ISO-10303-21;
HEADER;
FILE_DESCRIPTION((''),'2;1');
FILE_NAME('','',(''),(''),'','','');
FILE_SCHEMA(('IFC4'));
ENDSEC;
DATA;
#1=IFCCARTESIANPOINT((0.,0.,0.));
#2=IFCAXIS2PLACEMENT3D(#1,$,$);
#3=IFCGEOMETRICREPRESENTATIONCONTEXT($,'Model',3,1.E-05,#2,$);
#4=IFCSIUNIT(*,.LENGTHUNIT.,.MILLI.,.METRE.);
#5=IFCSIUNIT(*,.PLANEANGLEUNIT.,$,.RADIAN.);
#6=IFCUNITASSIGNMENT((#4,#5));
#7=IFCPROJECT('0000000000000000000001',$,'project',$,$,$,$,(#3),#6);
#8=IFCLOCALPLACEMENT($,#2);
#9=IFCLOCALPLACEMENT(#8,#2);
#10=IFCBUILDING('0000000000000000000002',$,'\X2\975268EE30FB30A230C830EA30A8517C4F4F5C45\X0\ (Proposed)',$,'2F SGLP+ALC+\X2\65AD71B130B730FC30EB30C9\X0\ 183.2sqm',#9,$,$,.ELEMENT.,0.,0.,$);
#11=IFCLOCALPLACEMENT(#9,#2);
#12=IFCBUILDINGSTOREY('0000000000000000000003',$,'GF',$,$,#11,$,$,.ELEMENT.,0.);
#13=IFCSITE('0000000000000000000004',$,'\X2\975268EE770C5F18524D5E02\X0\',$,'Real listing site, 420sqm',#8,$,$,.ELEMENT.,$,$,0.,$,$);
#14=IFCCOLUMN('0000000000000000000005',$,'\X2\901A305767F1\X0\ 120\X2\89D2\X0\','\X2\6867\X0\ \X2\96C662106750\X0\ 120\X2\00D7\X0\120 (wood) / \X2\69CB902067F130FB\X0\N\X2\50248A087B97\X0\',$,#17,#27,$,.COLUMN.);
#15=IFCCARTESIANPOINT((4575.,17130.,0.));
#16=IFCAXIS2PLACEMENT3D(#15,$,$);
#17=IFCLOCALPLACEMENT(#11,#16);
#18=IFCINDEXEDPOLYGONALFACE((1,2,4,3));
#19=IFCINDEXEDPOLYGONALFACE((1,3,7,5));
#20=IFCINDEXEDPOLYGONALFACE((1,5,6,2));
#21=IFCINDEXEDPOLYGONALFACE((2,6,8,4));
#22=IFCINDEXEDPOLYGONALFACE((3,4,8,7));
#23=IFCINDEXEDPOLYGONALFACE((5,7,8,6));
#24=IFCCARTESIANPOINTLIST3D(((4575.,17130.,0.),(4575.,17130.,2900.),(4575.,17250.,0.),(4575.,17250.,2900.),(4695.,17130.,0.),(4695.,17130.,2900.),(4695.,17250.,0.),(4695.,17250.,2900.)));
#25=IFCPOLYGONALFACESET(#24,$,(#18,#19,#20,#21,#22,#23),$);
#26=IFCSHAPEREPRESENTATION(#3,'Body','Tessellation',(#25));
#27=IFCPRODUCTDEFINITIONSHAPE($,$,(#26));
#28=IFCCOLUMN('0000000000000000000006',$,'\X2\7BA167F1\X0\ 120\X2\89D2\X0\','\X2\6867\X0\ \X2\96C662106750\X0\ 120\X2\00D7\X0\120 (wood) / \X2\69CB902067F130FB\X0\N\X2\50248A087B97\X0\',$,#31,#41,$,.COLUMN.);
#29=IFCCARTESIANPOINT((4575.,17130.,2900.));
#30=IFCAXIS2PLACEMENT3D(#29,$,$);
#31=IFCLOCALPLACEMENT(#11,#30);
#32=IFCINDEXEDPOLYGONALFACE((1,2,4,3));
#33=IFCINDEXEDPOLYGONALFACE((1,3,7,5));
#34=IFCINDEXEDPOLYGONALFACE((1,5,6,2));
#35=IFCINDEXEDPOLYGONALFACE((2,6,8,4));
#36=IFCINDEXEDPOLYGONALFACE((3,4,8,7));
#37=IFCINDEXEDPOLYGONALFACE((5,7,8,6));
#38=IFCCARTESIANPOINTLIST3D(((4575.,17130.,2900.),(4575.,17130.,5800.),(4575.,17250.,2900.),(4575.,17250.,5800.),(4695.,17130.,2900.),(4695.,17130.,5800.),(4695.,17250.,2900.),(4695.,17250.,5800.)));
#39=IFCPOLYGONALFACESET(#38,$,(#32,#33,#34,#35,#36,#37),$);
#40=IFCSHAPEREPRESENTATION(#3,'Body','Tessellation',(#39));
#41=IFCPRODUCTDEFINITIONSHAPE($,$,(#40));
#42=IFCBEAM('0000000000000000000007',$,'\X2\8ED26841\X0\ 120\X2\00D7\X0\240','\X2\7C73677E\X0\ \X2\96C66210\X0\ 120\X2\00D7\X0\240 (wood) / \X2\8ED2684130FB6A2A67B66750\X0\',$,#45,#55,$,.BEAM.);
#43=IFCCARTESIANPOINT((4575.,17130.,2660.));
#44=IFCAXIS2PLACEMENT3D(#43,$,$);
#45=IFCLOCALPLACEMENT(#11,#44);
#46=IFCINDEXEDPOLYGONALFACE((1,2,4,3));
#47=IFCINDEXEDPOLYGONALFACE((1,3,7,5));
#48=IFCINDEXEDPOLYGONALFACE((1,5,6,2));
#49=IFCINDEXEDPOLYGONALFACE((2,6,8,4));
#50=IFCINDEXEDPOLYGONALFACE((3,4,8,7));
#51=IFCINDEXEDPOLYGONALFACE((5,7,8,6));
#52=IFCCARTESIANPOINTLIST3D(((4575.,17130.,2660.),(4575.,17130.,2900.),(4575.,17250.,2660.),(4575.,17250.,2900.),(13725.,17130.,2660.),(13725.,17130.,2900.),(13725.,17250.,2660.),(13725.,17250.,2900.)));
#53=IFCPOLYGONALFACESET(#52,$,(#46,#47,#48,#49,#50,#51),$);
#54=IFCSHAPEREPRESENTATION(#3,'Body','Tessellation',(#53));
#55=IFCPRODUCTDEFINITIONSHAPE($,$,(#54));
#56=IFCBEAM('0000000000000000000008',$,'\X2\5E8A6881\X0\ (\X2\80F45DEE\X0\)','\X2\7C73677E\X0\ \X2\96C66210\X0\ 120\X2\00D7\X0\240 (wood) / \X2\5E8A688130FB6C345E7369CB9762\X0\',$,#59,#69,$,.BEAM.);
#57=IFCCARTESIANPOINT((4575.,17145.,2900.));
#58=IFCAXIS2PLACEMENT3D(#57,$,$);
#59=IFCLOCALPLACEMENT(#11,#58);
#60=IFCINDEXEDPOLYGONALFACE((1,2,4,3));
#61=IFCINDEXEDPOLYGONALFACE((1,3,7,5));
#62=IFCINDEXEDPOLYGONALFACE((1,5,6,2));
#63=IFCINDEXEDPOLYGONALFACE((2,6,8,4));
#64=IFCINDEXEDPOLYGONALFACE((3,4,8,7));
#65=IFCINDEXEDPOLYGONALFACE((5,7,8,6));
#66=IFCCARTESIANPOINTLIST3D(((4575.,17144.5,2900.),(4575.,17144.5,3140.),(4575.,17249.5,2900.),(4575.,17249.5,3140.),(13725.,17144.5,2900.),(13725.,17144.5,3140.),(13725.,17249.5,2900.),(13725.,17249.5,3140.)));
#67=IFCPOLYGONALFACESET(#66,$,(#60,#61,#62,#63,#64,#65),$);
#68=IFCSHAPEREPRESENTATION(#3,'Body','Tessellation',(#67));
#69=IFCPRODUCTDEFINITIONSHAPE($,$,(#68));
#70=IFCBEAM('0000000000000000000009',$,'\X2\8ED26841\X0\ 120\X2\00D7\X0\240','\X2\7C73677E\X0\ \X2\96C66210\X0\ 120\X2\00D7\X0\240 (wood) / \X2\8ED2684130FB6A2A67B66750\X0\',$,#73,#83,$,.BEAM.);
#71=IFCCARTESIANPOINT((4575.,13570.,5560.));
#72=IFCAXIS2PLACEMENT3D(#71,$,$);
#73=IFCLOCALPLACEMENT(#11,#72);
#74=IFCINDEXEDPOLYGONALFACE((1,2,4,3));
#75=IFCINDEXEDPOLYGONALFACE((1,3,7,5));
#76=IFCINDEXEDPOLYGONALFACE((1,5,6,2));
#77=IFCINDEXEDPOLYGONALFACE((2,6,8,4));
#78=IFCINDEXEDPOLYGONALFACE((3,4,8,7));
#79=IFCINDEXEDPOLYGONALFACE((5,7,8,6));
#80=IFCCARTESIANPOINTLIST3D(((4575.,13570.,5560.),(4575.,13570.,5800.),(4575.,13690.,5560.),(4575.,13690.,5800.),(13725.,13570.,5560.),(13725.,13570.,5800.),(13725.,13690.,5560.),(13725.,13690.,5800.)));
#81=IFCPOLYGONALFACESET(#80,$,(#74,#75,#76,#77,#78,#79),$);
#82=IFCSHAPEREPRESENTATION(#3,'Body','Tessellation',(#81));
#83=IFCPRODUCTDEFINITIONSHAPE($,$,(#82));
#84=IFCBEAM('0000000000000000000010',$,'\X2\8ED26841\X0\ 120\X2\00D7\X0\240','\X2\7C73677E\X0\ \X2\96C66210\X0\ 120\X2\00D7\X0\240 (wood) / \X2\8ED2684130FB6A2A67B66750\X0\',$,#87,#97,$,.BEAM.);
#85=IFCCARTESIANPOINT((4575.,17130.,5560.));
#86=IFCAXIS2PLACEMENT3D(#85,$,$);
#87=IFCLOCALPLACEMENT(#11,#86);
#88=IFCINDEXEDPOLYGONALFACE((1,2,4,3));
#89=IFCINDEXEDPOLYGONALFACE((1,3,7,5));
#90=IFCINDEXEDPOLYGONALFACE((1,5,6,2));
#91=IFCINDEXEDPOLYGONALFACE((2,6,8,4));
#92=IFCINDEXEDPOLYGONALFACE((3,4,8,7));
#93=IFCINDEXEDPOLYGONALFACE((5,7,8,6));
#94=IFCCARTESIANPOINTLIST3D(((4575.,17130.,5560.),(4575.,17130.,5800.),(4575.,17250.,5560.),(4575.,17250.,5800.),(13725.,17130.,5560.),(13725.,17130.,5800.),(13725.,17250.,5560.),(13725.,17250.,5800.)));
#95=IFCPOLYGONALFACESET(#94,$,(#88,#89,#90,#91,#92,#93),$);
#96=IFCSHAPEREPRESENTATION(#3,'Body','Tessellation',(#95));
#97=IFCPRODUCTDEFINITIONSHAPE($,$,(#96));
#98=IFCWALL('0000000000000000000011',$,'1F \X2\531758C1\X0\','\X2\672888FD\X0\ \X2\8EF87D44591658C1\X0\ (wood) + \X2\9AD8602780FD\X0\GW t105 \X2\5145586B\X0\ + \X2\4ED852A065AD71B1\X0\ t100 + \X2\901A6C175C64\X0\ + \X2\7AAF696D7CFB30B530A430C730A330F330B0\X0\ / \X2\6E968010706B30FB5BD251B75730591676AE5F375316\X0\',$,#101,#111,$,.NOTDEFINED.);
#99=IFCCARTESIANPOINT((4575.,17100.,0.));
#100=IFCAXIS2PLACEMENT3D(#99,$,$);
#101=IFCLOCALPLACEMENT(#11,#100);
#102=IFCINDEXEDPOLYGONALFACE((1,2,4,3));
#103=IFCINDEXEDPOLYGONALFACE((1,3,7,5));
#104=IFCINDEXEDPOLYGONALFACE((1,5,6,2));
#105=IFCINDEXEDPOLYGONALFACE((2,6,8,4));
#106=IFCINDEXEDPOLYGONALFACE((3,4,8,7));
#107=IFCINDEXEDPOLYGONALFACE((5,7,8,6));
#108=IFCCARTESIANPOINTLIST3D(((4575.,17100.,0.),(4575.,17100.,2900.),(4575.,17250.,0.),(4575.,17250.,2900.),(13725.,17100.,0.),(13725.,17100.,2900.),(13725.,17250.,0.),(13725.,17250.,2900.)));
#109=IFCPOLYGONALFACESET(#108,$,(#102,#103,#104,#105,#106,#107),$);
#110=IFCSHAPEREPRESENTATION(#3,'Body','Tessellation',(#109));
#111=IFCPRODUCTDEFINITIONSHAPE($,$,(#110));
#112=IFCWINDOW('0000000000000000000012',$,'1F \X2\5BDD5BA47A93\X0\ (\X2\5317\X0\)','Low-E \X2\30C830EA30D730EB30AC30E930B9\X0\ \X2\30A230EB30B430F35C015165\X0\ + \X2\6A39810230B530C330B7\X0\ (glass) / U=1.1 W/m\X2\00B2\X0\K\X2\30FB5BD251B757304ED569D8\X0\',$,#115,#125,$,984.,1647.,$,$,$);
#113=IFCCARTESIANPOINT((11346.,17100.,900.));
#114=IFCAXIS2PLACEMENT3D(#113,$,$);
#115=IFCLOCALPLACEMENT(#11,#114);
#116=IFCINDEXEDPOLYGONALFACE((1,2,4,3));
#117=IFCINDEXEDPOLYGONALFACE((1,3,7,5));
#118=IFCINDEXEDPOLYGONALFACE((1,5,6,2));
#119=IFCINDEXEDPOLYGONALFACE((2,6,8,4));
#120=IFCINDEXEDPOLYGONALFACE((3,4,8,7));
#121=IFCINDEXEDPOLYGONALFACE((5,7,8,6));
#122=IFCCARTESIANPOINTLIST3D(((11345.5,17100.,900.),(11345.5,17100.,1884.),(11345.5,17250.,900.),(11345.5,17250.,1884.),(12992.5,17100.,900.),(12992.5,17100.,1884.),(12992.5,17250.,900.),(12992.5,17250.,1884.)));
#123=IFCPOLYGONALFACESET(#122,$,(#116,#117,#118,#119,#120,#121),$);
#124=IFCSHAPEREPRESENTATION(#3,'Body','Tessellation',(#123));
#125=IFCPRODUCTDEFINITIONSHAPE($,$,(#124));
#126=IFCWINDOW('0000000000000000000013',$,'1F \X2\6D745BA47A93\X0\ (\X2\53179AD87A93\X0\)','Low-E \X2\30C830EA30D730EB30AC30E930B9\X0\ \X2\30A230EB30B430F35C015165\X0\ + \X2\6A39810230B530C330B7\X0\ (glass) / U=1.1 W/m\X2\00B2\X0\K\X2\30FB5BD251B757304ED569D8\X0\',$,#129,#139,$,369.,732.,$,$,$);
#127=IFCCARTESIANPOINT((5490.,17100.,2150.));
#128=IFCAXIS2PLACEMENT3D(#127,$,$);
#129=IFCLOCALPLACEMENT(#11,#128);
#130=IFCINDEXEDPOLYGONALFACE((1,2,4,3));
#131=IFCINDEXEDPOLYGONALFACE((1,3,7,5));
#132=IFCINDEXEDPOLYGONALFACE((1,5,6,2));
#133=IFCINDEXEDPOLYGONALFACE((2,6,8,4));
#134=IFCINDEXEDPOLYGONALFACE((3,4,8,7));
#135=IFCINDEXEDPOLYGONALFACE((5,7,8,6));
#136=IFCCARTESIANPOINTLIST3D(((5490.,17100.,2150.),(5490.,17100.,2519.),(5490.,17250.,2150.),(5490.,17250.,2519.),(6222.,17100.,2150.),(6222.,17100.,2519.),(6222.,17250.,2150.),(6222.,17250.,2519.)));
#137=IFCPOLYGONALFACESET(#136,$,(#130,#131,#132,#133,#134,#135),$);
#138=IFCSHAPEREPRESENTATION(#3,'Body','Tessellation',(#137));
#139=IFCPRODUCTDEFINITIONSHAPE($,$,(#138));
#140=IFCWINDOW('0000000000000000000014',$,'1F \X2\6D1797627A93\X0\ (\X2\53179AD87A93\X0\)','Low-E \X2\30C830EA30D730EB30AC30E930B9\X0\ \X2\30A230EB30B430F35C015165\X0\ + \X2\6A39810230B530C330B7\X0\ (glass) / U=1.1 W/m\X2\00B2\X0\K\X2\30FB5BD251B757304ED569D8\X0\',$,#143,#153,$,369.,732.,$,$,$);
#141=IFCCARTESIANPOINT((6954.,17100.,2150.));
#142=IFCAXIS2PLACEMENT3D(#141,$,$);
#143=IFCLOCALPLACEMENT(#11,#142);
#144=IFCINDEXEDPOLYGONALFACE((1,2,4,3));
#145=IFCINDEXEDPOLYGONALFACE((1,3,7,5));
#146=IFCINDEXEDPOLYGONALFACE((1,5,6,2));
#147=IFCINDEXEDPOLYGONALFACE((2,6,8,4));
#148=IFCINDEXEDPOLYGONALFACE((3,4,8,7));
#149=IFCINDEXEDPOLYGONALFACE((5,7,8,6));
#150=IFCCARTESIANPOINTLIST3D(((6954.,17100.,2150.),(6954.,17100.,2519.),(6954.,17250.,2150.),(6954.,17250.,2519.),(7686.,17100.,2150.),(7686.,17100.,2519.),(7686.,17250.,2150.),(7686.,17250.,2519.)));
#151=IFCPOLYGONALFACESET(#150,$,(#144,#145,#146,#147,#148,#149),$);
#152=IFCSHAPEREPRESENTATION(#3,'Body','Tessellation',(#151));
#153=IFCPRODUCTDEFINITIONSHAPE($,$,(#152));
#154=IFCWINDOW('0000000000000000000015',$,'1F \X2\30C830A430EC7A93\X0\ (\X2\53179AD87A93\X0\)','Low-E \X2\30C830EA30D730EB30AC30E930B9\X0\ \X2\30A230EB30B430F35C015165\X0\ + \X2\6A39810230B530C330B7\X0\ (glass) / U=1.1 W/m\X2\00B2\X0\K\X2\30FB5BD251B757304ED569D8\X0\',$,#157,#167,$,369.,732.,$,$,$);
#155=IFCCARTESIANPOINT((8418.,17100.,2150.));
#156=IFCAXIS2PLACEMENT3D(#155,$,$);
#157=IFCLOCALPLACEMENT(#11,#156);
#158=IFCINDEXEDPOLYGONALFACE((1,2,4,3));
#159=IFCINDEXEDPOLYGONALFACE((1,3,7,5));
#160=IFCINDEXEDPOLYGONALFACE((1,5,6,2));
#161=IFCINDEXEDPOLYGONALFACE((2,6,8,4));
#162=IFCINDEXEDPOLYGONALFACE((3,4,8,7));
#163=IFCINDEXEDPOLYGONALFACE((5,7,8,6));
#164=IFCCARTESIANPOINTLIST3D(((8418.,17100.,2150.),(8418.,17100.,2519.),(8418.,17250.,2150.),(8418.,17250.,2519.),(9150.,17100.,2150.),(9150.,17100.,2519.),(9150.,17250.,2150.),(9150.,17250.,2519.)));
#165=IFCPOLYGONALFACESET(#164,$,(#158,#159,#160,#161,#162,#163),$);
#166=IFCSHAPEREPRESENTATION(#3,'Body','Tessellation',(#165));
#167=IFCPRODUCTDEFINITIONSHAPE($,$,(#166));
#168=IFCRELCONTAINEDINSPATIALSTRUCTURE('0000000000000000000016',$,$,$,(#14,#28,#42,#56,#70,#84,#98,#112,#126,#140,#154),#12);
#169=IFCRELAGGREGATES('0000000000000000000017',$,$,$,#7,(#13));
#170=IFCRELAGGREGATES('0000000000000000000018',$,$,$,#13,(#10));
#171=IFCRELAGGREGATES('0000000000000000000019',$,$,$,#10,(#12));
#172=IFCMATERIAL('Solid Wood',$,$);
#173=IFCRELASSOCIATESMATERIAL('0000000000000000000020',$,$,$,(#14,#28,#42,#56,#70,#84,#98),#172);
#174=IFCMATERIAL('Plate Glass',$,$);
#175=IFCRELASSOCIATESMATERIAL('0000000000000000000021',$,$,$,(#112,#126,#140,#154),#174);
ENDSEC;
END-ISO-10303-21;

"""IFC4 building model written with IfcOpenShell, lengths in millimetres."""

from ifc_helpers import new_model, si_unit, frame, frame_2d, origin, place, context, project, spatial, rectangle, extrude, material, element, fill, save


model = new_model("IFC4")

# Units and contexts
model_context = context("Model", 3, precision=1e-05, world=origin())
ifc_project = project(units=[si_unit("LENGTHUNIT", "METRE", prefix="MILLI"), si_unit("PLANEANGLEUNIT", "RADIAN")], contexts=[model_context])

# Site, building, storey
site_placement = place(None, origin())
site = spatial("IfcSite", under=ifc_project, at=site_placement, Name="青森県弘前市", ObjectType="Real listing site, 420sqm", CompositionType="ELEMENT", RefElevation=0.0)
building_placement = place(site_placement, origin())
building = spatial("IfcBuilding", under=site, at=building_placement, Name="青森・アトリエ兼住居 (Proposed)", ObjectType="2F SGLP+ALC+断熱シールド 183.2sqm", CompositionType="ELEMENT", ElevationOfRefHeight=0.0, ElevationOfTerrain=0.0)
storey_placement = place(building_placement, origin())
storey = spatial("IfcBuildingStorey", under=building, at=storey_placement, Name="GF", CompositionType="ELEMENT", Elevation=0.0)

# Columns
ifc_material_1 = material(Name="Solid Wood")
column_1_placement = place(storey_placement, frame((4575.0, 17130.0, 0.0)))
element("IfcColumn", 1, at=column_1_placement, inside=storey, material=ifc_material_1, Name="通し柱 120角", Description="桧 集成材 120×120 (wood) / 構造柱・N値計算", PredefinedType="COLUMN", context=model_context, shape_type="SweptSolid", body=[
    extrude(rectangle(XDim=120.0, YDim=120.0, at=frame_2d((60.0, 60.0))), frame((4575.0, 17130.0, 0.0)), (0.0, 0.0, 1.0), 2900.0),
])
column_2_placement = place(storey_placement, frame((4575.0, 17130.0, 2900.0)))
element("IfcColumn", 2, at=column_2_placement, inside=storey, material=ifc_material_1, Name="管柱 120角", Description="桧 集成材 120×120 (wood) / 構造柱・N値計算", PredefinedType="COLUMN", context=model_context, shape_type="SweptSolid", body=[
    extrude(rectangle(XDim=120.0, YDim=120.0, at=frame_2d((60.0, 60.0))), frame((4575.0, 17130.0, 2900.0)), (0.0, 0.0, 1.0), 2900.0),
])

# Beams
beam_1_placement = place(storey_placement, frame((4575.0, 17130.0, 2660.0)))
element("IfcBeam", 3, at=beam_1_placement, inside=storey, material=ifc_material_1, Name="軒桁 120×240", Description="米松 集成 120×240 (wood) / 軒桁・横架材", PredefinedType="BEAM", context=model_context, shape_type="SweptSolid", body=[
    extrude(rectangle(XDim=9150.0, YDim=120.0, at=frame_2d((4575.0, 60.0))), frame((4575.0, 17130.0, 2660.0)), (0.0, 0.0, 1.0), 240.0),
])
beam_2_placement = place(storey_placement, frame((4575.0, 17145.0, 2900.0)))
element("IfcBeam", 4, at=beam_2_placement, inside=storey, material=ifc_material_1, Name="床梁 (胴差)", Description="米松 集成 120×240 (wood) / 床梁・水平構面", PredefinedType="BEAM", context=model_context, shape_type="SweptSolid", body=[
    extrude(rectangle(XDim=9150.0, YDim=105.0, at=frame_2d((4575.0, 52.0))), frame((4575.0, 17145.0, 2900.0)), (0.0, 0.0, 1.0), 240.0),
])
beam_3_placement = place(storey_placement, frame((4575.0, 13570.0, 5560.0)))
element("IfcBeam", 5, at=beam_3_placement, inside=storey, material=ifc_material_1, Name="軒桁 120×240", Description="米松 集成 120×240 (wood) / 軒桁・横架材", PredefinedType="BEAM", context=model_context, shape_type="SweptSolid", body=[
    extrude(rectangle(XDim=9150.0, YDim=120.0, at=frame_2d((4575.0, 60.0))), frame((4575.0, 13570.0, 5560.0)), (0.0, 0.0, 1.0), 240.0),
])
beam_4_placement = place(storey_placement, frame((4575.0, 17130.0, 5560.0)))
element("IfcBeam", 6, at=beam_4_placement, inside=storey, material=ifc_material_1, Name="軒桁 120×240", Description="米松 集成 120×240 (wood) / 軒桁・横架材", PredefinedType="BEAM", context=model_context, shape_type="SweptSolid", body=[
    extrude(rectangle(XDim=9150.0, YDim=120.0, at=frame_2d((4575.0, 60.0))), frame((4575.0, 17130.0, 5560.0)), (0.0, 0.0, 1.0), 240.0),
])

# Wall, openings, windows
wall_1_placement = place(storey_placement, frame((4575.0, 17100.0, 0.0)))
wall_1 = element("IfcWall", 7, at=wall_1_placement, inside=storey, material=ifc_material_1, Name="1F 北壁", Description="木製 軸組外壁 (wood) + 高性能GW t105 充填 + 付加断熱 t100 + 通気層 + 窯業系サイディング / 準耐火・寒冷地外皮強化", PredefinedType="NOTDEFINED", context=model_context, shape_type="SweptSolid", body=[
    extrude(rectangle(XDim=9150.0, YDim=150.0, at=frame_2d((4575.0, 75.0))), frame((4575.0, 17100.0, 0.0)), (0.0, 0.0, 1.0), 2900.0),
])
opening_1_placement = place(storey_placement, frame((11346.0, 17100.0, 900.0)))
opening_1 = element("IfcOpeningElement", 8, at=opening_1_placement, cuts=wall_1, PredefinedType="NOTDEFINED", context=model_context, shape_type="SweptSolid", body=[
    extrude(rectangle(XDim=1647.0, YDim=150.0, at=frame_2d((823.0, 75.0))), frame((11346.0, 17100.0, 900.0)), (0.0, 0.0, 1.0), 984.0),
])
opening_2_placement = place(storey_placement, frame((5490.0, 17100.0, 2150.0)))
opening_2 = element("IfcOpeningElement", 9, at=opening_2_placement, cuts=wall_1, PredefinedType="NOTDEFINED", context=model_context, shape_type="SweptSolid", body=[
    extrude(rectangle(XDim=732.0, YDim=150.0, at=frame_2d((366.0, 75.0))), frame((5490.0, 17100.0, 2150.0)), (0.0, 0.0, 1.0), 369.0),
])
opening_3_placement = place(storey_placement, frame((6954.0, 17100.0, 2150.0)))
opening_3 = element("IfcOpeningElement", 10, at=opening_3_placement, cuts=wall_1, PredefinedType="NOTDEFINED", context=model_context, shape_type="SweptSolid", body=[
    extrude(rectangle(XDim=732.0, YDim=150.0, at=frame_2d((366.0, 75.0))), frame((6954.0, 17100.0, 2150.0)), (0.0, 0.0, 1.0), 369.0),
])
opening_4_placement = place(storey_placement, frame((8418.0, 17100.0, 2150.0)))
opening_4 = element("IfcOpeningElement", 11, at=opening_4_placement, cuts=wall_1, PredefinedType="NOTDEFINED", context=model_context, shape_type="SweptSolid", body=[
    extrude(rectangle(XDim=732.0, YDim=150.0, at=frame_2d((366.0, 75.0))), frame((8418.0, 17100.0, 2150.0)), (0.0, 0.0, 1.0), 369.0),
])
ifc_material_2 = material(Name="Plate Glass")
window_1_placement = place(storey_placement, frame((11346.0, 17100.0, 900.0)))
window_1 = element("IfcWindow", 12, at=window_1_placement, inside=storey, material=ifc_material_2, Name="1F 寝室窓 (北)", Description="Low-E トリプルガラス アルゴン封入 + 樹脂サッシ (glass) / U=1.1 W/m²K・寒冷地仕様", OverallHeight=984.0, OverallWidth=1647.0, context=model_context, shape_type="SweptSolid", body=[
    extrude(rectangle(XDim=1647.0, YDim=150.0, at=frame_2d((823.0, 75.0))), frame((11346.0, 17100.0, 900.0)), (0.0, 0.0, 1.0), 984.0),
])
fill(opening_1, window_1)
window_2_placement = place(storey_placement, frame((5490.0, 17100.0, 2150.0)))
window_2 = element("IfcWindow", 13, at=window_2_placement, inside=storey, material=ifc_material_2, Name="1F 浴室窓 (北高窓)", Description="Low-E トリプルガラス アルゴン封入 + 樹脂サッシ (glass) / U=1.1 W/m²K・寒冷地仕様", OverallHeight=369.0, OverallWidth=732.0, context=model_context, shape_type="SweptSolid", body=[
    extrude(rectangle(XDim=732.0, YDim=150.0, at=frame_2d((366.0, 75.0))), frame((5490.0, 17100.0, 2150.0)), (0.0, 0.0, 1.0), 369.0),
])
fill(opening_2, window_2)
window_3_placement = place(storey_placement, frame((6954.0, 17100.0, 2150.0)))
window_3 = element("IfcWindow", 14, at=window_3_placement, inside=storey, material=ifc_material_2, Name="1F 洗面窓 (北高窓)", Description="Low-E トリプルガラス アルゴン封入 + 樹脂サッシ (glass) / U=1.1 W/m²K・寒冷地仕様", OverallHeight=369.0, OverallWidth=732.0, context=model_context, shape_type="SweptSolid", body=[
    extrude(rectangle(XDim=732.0, YDim=150.0, at=frame_2d((366.0, 75.0))), frame((6954.0, 17100.0, 2150.0)), (0.0, 0.0, 1.0), 369.0),
])
fill(opening_3, window_3)
window_4_placement = place(storey_placement, frame((8418.0, 17100.0, 2150.0)))
window_4 = element("IfcWindow", 15, at=window_4_placement, inside=storey, material=ifc_material_2, Name="1F トイレ窓 (北高窓)", Description="Low-E トリプルガラス アルゴン封入 + 樹脂サッシ (glass) / U=1.1 W/m²K・寒冷地仕様", OverallHeight=369.0, OverallWidth=732.0, context=model_context, shape_type="SweptSolid", body=[
    extrude(rectangle(XDim=732.0, YDim=150.0, at=frame_2d((366.0, 75.0))), frame((8418.0, 17100.0, 2150.0)), (0.0, 0.0, 1.0), 369.0),
])
fill(opening_4, window_4)

save(model, "model.ifc")
